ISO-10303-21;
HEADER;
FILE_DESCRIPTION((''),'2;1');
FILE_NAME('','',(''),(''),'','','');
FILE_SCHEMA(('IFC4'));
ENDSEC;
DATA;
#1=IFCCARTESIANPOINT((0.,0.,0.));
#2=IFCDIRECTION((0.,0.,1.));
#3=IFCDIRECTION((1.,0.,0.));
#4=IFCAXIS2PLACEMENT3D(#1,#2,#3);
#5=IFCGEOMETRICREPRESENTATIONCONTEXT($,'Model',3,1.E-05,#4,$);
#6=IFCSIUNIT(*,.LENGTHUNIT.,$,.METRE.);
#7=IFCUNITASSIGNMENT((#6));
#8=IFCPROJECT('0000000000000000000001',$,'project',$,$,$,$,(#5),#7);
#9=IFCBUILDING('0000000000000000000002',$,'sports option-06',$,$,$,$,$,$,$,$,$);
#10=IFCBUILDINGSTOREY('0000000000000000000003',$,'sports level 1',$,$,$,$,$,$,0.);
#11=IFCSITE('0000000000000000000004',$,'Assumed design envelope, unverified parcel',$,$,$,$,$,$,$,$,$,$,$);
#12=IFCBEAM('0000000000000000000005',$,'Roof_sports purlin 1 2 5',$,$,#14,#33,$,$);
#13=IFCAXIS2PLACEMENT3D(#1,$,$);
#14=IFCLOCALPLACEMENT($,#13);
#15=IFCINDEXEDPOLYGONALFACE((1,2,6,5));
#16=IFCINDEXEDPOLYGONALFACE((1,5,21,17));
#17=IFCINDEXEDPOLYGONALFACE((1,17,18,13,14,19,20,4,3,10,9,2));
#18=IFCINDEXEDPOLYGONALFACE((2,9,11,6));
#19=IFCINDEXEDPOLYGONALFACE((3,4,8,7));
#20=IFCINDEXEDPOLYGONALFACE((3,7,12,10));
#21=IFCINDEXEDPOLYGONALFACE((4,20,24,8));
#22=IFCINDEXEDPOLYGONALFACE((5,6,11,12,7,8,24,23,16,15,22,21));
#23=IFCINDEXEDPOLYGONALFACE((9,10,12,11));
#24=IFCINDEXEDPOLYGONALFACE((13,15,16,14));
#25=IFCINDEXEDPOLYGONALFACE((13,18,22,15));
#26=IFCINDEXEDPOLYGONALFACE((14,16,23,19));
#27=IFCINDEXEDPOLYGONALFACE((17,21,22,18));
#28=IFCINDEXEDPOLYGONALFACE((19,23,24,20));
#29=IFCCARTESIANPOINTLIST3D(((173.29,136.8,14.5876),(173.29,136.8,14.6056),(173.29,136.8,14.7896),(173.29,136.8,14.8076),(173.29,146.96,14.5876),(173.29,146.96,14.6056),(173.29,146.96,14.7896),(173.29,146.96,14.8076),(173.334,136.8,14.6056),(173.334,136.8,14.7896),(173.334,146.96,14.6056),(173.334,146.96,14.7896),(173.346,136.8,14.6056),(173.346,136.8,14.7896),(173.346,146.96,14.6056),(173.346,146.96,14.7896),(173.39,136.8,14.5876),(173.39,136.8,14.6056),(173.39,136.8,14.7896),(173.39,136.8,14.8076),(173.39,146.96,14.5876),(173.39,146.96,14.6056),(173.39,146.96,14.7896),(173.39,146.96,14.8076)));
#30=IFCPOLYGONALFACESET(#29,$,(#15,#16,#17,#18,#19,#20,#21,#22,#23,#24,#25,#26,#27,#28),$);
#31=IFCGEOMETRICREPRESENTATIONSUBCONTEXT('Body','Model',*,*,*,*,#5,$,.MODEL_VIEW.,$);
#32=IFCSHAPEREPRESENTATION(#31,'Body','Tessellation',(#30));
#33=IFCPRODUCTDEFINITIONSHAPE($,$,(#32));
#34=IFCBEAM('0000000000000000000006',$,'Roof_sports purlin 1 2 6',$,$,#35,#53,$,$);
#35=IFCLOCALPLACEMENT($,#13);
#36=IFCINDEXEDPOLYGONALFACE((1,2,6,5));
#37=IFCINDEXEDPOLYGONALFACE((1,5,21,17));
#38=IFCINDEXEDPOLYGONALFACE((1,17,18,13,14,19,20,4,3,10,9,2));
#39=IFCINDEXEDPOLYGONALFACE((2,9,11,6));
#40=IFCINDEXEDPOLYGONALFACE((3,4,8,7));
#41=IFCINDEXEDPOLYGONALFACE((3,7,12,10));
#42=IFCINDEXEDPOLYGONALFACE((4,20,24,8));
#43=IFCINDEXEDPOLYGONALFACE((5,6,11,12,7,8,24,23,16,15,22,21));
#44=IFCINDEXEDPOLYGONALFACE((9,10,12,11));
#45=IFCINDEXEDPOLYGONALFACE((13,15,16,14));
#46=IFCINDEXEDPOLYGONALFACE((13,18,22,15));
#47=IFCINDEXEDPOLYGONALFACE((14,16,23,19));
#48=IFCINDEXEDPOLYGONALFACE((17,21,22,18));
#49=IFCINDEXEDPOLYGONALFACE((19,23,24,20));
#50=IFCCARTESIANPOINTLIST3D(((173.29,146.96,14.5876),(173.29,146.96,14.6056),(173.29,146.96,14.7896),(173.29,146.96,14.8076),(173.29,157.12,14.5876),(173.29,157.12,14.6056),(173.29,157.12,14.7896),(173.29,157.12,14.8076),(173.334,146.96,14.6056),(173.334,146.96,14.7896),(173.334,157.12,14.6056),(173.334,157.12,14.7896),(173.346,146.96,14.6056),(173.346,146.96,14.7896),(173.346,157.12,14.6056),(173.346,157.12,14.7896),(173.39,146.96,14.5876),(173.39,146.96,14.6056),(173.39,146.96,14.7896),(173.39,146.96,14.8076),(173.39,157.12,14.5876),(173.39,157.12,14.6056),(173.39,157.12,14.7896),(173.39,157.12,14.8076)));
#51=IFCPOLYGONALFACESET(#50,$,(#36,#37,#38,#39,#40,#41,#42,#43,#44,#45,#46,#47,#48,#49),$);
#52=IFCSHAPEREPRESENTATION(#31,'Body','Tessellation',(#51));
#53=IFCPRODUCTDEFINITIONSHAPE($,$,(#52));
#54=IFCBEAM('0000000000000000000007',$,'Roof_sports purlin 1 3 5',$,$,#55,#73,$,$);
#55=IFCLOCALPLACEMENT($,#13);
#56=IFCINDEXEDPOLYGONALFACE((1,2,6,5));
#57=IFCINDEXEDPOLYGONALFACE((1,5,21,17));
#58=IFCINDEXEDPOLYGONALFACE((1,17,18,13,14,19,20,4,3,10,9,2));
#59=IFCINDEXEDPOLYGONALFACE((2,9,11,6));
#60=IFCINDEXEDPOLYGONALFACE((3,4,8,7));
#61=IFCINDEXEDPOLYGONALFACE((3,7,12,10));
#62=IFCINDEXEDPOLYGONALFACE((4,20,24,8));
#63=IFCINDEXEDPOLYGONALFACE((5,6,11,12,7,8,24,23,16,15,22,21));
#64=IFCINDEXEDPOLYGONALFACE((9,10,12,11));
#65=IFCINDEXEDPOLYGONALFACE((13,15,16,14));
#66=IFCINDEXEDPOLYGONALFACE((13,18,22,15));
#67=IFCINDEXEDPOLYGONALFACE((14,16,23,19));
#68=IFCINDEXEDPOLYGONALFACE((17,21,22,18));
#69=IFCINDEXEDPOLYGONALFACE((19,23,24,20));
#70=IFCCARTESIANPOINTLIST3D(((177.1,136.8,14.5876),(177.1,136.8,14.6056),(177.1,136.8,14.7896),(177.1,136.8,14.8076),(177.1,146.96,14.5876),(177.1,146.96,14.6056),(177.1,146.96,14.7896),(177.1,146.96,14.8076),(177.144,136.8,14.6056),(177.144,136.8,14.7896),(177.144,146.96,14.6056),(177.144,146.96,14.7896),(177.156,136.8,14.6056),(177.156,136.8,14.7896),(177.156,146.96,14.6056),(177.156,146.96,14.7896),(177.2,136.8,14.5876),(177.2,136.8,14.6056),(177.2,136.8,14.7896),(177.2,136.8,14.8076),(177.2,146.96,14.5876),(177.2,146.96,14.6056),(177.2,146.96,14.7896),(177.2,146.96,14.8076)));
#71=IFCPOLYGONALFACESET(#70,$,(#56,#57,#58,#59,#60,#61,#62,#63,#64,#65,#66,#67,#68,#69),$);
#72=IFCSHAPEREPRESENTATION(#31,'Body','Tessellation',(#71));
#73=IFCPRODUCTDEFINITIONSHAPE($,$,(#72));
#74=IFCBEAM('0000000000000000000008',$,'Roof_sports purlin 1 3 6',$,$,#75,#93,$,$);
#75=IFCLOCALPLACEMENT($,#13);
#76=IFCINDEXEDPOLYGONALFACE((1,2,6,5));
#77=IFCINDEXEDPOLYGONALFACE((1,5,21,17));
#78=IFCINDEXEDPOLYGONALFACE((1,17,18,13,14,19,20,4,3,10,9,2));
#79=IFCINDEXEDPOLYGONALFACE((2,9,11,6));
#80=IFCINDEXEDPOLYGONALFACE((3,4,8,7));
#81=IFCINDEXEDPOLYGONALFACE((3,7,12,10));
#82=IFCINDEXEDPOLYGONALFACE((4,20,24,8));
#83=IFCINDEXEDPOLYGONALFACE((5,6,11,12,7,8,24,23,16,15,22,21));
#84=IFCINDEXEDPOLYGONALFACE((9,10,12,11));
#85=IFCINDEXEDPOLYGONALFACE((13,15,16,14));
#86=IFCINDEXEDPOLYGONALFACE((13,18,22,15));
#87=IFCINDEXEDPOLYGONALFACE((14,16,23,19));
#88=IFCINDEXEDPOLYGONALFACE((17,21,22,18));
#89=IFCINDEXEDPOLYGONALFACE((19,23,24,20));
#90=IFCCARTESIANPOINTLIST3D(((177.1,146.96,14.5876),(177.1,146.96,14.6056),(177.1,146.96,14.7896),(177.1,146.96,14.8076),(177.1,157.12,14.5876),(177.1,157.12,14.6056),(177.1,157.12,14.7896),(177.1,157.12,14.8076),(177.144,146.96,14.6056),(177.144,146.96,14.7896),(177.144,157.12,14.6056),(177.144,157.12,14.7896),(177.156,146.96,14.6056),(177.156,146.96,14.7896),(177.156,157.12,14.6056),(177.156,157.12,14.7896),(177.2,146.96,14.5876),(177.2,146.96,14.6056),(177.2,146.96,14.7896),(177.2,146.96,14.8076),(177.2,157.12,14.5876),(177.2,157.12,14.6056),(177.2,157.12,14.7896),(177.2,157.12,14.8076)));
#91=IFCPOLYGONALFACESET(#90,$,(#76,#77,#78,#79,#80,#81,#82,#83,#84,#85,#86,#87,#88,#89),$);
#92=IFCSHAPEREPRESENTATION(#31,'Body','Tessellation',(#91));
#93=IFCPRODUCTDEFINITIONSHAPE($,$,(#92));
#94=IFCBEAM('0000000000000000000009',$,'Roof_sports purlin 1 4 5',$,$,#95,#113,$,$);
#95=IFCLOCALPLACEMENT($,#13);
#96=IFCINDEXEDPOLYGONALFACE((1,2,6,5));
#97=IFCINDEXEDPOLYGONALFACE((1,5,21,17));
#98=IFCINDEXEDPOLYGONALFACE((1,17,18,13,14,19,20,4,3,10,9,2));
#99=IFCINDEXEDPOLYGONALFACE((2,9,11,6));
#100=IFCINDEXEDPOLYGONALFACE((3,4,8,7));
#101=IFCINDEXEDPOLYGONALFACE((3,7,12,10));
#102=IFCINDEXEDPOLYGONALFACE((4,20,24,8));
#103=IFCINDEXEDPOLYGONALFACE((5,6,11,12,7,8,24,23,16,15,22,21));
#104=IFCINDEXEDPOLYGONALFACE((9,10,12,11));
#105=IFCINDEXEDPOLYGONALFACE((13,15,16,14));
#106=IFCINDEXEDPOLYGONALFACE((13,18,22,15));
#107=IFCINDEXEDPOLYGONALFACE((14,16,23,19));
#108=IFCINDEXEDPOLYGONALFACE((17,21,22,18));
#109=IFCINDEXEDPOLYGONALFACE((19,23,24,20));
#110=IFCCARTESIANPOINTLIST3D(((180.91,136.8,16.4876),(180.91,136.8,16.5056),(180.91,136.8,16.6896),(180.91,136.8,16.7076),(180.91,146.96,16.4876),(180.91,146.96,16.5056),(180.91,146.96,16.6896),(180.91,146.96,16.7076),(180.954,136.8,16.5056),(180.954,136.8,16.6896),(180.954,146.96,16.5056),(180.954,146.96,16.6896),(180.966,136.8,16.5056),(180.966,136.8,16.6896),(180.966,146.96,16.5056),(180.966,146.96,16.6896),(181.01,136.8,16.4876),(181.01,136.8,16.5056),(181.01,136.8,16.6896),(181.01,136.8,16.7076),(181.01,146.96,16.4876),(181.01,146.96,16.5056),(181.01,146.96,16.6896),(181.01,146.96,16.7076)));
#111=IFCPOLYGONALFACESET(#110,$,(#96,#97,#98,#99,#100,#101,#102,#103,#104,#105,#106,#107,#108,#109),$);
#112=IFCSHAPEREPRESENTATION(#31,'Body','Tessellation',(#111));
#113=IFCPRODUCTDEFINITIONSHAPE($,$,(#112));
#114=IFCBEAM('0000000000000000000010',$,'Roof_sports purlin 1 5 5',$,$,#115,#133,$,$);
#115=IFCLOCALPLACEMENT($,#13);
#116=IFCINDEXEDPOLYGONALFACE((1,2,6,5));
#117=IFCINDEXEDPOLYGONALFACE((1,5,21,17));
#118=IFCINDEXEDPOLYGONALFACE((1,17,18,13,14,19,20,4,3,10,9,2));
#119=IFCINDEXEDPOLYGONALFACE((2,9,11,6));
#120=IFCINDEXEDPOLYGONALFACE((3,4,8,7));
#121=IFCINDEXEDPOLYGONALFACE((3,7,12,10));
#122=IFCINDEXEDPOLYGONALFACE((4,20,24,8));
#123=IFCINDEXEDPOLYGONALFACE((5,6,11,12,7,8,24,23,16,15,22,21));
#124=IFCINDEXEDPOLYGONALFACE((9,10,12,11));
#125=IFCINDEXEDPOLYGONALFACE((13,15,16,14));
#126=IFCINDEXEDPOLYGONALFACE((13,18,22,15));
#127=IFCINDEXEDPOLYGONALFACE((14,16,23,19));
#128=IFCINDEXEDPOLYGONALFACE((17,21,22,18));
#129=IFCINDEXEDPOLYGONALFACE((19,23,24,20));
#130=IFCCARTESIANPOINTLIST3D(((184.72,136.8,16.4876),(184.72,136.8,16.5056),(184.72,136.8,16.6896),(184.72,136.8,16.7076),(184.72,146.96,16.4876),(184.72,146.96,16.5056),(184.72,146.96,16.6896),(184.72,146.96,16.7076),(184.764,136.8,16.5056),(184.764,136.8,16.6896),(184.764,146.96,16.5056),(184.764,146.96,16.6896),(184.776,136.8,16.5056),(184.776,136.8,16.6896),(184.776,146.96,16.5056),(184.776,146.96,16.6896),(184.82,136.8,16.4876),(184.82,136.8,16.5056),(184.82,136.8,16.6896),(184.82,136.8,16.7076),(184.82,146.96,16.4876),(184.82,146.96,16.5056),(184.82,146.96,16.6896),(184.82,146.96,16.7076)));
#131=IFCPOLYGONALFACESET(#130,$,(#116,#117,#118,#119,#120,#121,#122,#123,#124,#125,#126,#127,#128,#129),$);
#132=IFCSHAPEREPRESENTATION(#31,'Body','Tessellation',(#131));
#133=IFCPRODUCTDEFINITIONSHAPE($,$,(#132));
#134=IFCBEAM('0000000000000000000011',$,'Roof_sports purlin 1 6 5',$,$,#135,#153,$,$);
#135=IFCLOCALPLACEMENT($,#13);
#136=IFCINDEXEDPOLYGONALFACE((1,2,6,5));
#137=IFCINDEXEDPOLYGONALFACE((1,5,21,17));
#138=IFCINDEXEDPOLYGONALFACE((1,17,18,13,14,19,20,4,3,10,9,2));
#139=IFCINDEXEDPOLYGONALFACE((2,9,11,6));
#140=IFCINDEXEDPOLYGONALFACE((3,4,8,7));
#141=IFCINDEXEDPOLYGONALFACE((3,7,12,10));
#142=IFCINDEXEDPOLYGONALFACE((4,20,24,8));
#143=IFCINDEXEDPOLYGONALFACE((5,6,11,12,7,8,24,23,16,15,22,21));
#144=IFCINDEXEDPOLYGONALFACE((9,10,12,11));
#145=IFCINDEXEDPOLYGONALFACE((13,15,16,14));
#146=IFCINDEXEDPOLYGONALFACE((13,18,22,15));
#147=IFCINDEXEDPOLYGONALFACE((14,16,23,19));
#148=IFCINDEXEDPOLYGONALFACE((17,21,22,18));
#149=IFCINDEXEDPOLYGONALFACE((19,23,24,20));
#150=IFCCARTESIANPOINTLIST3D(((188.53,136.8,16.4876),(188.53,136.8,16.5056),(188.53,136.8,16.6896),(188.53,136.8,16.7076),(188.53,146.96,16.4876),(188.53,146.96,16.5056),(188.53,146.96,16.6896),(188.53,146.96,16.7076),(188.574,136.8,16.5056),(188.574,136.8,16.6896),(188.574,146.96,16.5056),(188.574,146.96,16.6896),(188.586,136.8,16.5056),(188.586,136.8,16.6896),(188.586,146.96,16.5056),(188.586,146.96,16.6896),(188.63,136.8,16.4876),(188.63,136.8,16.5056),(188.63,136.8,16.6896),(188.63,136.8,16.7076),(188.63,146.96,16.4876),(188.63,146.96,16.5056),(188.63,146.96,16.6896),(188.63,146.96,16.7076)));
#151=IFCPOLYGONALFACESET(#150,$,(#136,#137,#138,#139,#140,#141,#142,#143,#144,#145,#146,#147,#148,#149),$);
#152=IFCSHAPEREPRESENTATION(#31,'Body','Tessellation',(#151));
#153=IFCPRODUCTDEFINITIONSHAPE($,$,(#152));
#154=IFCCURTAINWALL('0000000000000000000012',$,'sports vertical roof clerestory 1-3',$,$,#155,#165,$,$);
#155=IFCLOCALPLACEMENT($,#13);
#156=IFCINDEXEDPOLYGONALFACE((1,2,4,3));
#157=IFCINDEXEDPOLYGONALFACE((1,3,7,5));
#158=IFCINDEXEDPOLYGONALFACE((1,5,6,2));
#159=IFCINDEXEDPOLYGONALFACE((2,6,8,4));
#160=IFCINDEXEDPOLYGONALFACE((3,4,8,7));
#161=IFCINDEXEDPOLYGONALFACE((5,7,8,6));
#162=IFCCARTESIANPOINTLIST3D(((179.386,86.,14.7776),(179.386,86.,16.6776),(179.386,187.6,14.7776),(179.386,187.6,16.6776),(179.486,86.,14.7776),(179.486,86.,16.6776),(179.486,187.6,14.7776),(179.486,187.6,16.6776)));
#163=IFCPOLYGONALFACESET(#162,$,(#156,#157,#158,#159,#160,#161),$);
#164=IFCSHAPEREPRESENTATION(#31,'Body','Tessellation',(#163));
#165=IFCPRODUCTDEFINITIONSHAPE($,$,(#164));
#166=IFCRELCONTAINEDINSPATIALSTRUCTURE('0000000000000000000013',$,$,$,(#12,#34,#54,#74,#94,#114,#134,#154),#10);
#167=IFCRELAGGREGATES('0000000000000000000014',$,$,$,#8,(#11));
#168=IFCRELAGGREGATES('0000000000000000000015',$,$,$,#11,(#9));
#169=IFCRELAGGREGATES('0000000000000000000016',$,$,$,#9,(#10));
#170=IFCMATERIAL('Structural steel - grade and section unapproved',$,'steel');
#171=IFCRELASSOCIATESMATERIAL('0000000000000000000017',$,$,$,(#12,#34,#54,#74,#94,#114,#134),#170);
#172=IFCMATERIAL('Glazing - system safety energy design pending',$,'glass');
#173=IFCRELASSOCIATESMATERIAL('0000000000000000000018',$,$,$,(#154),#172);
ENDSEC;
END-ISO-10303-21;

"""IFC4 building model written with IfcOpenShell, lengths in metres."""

from ifc_helpers import new_model, si_unit, frame, origin_with_axes, place, context, subcontext, project, spatial, rectangle, i_section, extrude, material, element, save


model = new_model("IFC4")

# Units and contexts
model_context = context("Model", 3, precision=1e-05, world=origin_with_axes())
body_context = subcontext(model_context, "Body", "Model", "MODEL_VIEW")
ifc_project = project(units=[si_unit("LENGTHUNIT", "METRE")], contexts=[model_context])

# Site, building, storey
site = spatial("IfcSite", under=ifc_project, Name="Assumed design envelope, unverified parcel")
building = spatial("IfcBuilding", under=site, Name="sports option-06")
storey = spatial("IfcBuildingStorey", under=building, Name="sports level 1", Elevation=0.0)

# Beams
ifc_material_1 = material(Name="Structural steel - grade and section unapproved", Category="steel")
beam_1_placement = place(None, frame((173.34, 136.8, 14.6976), z_axis=(0.0, 1.0, 0.0), x_axis=(-1.0, 0.0, 0.0)))
element("IfcBeam", 1, at=beam_1_placement, inside=storey, material=ifc_material_1, Name="Roof_sports purlin 1 2 5", context=body_context, shape_type="SweptSolid", body=[
    extrude(i_section(OverallWidth=0.1, OverallDepth=0.22, WebThickness=0.012, FlangeThickness=0.018, FilletRadius=0.0), origin_with_axes(), (0.0, 0.0, 1.0), 10.16),
])
beam_2_placement = place(None, frame((173.34, 146.96, 14.6976), z_axis=(0.0, 1.0, 0.0), x_axis=(-1.0, 0.0, 0.0)))
element("IfcBeam", 2, at=beam_2_placement, inside=storey, material=ifc_material_1, Name="Roof_sports purlin 1 2 6", context=body_context, shape_type="SweptSolid", body=[
    extrude(i_section(OverallWidth=0.1, OverallDepth=0.22, WebThickness=0.012, FlangeThickness=0.018, FilletRadius=0.0), origin_with_axes(), (0.0, 0.0, 1.0), 10.16),
])
beam_3_placement = place(None, frame((177.15, 136.8, 14.6976), z_axis=(0.0, 1.0, 0.0), x_axis=(-1.0, 0.0, 0.0)))
element("IfcBeam", 3, at=beam_3_placement, inside=storey, material=ifc_material_1, Name="Roof_sports purlin 1 3 5", context=body_context, shape_type="SweptSolid", body=[
    extrude(i_section(OverallWidth=0.1, OverallDepth=0.22, WebThickness=0.012, FlangeThickness=0.018, FilletRadius=0.0), origin_with_axes(), (0.0, 0.0, 1.0), 10.16),
])
beam_4_placement = place(None, frame((177.15, 146.96, 14.6976), z_axis=(0.0, 1.0, 0.0), x_axis=(-1.0, 0.0, 0.0)))
element("IfcBeam", 4, at=beam_4_placement, inside=storey, material=ifc_material_1, Name="Roof_sports purlin 1 3 6", context=body_context, shape_type="SweptSolid", body=[
    extrude(i_section(OverallWidth=0.1, OverallDepth=0.22, WebThickness=0.012, FlangeThickness=0.018, FilletRadius=0.0), origin_with_axes(), (0.0, 0.0, 1.0), 10.16),
])
for number, where, z_axis, x_axis, name in (
    (5, (180.96, 136.8, 16.5976), (0.0, 1.0, 0.0), (-1.0, 0.0, 0.0), "Roof_sports purlin 1 4 5"),
    (6, (184.77, 136.8, 16.5976), (0.0, 1.0, 0.0), (-1.0, 0.0, 0.0), "Roof_sports purlin 1 5 5"),
    (7, (188.58, 136.8, 16.5976), (0.0, 1.0, 0.0), (-1.0, 0.0, 0.0), "Roof_sports purlin 1 6 5"),
):
    element("IfcBeam", number, at=place(None, frame(where, z_axis=z_axis, x_axis=x_axis)), inside=storey, material=ifc_material_1, Name=name, context=body_context, shape_type="SweptSolid", body=[
        extrude(i_section(OverallWidth=0.1, OverallDepth=0.22, WebThickness=0.012, FlangeThickness=0.018, FilletRadius=0.0), origin_with_axes(), (0.0, 0.0, 1.0), 10.16),
    ])

# Curtain wall
ifc_material_2 = material(Name="Glazing - system safety energy design pending", Category="glass")
curtain_wall_placement = place(None, frame((179.436, 136.8, 14.7776), z_axis=(0.0, 0.0, 1.0), x_axis=(1.0, 0.0, 0.0)))
element("IfcCurtainWall", 8, at=curtain_wall_placement, inside=storey, material=ifc_material_2, Name="sports vertical roof clerestory 1-3", context=body_context, shape_type="SweptSolid", body=[
    extrude(rectangle(XDim=0.1, YDim=101.6), origin_with_axes(), (0.0, 0.0, 1.0), 1.9),
])

save(model, "model.ifc")
